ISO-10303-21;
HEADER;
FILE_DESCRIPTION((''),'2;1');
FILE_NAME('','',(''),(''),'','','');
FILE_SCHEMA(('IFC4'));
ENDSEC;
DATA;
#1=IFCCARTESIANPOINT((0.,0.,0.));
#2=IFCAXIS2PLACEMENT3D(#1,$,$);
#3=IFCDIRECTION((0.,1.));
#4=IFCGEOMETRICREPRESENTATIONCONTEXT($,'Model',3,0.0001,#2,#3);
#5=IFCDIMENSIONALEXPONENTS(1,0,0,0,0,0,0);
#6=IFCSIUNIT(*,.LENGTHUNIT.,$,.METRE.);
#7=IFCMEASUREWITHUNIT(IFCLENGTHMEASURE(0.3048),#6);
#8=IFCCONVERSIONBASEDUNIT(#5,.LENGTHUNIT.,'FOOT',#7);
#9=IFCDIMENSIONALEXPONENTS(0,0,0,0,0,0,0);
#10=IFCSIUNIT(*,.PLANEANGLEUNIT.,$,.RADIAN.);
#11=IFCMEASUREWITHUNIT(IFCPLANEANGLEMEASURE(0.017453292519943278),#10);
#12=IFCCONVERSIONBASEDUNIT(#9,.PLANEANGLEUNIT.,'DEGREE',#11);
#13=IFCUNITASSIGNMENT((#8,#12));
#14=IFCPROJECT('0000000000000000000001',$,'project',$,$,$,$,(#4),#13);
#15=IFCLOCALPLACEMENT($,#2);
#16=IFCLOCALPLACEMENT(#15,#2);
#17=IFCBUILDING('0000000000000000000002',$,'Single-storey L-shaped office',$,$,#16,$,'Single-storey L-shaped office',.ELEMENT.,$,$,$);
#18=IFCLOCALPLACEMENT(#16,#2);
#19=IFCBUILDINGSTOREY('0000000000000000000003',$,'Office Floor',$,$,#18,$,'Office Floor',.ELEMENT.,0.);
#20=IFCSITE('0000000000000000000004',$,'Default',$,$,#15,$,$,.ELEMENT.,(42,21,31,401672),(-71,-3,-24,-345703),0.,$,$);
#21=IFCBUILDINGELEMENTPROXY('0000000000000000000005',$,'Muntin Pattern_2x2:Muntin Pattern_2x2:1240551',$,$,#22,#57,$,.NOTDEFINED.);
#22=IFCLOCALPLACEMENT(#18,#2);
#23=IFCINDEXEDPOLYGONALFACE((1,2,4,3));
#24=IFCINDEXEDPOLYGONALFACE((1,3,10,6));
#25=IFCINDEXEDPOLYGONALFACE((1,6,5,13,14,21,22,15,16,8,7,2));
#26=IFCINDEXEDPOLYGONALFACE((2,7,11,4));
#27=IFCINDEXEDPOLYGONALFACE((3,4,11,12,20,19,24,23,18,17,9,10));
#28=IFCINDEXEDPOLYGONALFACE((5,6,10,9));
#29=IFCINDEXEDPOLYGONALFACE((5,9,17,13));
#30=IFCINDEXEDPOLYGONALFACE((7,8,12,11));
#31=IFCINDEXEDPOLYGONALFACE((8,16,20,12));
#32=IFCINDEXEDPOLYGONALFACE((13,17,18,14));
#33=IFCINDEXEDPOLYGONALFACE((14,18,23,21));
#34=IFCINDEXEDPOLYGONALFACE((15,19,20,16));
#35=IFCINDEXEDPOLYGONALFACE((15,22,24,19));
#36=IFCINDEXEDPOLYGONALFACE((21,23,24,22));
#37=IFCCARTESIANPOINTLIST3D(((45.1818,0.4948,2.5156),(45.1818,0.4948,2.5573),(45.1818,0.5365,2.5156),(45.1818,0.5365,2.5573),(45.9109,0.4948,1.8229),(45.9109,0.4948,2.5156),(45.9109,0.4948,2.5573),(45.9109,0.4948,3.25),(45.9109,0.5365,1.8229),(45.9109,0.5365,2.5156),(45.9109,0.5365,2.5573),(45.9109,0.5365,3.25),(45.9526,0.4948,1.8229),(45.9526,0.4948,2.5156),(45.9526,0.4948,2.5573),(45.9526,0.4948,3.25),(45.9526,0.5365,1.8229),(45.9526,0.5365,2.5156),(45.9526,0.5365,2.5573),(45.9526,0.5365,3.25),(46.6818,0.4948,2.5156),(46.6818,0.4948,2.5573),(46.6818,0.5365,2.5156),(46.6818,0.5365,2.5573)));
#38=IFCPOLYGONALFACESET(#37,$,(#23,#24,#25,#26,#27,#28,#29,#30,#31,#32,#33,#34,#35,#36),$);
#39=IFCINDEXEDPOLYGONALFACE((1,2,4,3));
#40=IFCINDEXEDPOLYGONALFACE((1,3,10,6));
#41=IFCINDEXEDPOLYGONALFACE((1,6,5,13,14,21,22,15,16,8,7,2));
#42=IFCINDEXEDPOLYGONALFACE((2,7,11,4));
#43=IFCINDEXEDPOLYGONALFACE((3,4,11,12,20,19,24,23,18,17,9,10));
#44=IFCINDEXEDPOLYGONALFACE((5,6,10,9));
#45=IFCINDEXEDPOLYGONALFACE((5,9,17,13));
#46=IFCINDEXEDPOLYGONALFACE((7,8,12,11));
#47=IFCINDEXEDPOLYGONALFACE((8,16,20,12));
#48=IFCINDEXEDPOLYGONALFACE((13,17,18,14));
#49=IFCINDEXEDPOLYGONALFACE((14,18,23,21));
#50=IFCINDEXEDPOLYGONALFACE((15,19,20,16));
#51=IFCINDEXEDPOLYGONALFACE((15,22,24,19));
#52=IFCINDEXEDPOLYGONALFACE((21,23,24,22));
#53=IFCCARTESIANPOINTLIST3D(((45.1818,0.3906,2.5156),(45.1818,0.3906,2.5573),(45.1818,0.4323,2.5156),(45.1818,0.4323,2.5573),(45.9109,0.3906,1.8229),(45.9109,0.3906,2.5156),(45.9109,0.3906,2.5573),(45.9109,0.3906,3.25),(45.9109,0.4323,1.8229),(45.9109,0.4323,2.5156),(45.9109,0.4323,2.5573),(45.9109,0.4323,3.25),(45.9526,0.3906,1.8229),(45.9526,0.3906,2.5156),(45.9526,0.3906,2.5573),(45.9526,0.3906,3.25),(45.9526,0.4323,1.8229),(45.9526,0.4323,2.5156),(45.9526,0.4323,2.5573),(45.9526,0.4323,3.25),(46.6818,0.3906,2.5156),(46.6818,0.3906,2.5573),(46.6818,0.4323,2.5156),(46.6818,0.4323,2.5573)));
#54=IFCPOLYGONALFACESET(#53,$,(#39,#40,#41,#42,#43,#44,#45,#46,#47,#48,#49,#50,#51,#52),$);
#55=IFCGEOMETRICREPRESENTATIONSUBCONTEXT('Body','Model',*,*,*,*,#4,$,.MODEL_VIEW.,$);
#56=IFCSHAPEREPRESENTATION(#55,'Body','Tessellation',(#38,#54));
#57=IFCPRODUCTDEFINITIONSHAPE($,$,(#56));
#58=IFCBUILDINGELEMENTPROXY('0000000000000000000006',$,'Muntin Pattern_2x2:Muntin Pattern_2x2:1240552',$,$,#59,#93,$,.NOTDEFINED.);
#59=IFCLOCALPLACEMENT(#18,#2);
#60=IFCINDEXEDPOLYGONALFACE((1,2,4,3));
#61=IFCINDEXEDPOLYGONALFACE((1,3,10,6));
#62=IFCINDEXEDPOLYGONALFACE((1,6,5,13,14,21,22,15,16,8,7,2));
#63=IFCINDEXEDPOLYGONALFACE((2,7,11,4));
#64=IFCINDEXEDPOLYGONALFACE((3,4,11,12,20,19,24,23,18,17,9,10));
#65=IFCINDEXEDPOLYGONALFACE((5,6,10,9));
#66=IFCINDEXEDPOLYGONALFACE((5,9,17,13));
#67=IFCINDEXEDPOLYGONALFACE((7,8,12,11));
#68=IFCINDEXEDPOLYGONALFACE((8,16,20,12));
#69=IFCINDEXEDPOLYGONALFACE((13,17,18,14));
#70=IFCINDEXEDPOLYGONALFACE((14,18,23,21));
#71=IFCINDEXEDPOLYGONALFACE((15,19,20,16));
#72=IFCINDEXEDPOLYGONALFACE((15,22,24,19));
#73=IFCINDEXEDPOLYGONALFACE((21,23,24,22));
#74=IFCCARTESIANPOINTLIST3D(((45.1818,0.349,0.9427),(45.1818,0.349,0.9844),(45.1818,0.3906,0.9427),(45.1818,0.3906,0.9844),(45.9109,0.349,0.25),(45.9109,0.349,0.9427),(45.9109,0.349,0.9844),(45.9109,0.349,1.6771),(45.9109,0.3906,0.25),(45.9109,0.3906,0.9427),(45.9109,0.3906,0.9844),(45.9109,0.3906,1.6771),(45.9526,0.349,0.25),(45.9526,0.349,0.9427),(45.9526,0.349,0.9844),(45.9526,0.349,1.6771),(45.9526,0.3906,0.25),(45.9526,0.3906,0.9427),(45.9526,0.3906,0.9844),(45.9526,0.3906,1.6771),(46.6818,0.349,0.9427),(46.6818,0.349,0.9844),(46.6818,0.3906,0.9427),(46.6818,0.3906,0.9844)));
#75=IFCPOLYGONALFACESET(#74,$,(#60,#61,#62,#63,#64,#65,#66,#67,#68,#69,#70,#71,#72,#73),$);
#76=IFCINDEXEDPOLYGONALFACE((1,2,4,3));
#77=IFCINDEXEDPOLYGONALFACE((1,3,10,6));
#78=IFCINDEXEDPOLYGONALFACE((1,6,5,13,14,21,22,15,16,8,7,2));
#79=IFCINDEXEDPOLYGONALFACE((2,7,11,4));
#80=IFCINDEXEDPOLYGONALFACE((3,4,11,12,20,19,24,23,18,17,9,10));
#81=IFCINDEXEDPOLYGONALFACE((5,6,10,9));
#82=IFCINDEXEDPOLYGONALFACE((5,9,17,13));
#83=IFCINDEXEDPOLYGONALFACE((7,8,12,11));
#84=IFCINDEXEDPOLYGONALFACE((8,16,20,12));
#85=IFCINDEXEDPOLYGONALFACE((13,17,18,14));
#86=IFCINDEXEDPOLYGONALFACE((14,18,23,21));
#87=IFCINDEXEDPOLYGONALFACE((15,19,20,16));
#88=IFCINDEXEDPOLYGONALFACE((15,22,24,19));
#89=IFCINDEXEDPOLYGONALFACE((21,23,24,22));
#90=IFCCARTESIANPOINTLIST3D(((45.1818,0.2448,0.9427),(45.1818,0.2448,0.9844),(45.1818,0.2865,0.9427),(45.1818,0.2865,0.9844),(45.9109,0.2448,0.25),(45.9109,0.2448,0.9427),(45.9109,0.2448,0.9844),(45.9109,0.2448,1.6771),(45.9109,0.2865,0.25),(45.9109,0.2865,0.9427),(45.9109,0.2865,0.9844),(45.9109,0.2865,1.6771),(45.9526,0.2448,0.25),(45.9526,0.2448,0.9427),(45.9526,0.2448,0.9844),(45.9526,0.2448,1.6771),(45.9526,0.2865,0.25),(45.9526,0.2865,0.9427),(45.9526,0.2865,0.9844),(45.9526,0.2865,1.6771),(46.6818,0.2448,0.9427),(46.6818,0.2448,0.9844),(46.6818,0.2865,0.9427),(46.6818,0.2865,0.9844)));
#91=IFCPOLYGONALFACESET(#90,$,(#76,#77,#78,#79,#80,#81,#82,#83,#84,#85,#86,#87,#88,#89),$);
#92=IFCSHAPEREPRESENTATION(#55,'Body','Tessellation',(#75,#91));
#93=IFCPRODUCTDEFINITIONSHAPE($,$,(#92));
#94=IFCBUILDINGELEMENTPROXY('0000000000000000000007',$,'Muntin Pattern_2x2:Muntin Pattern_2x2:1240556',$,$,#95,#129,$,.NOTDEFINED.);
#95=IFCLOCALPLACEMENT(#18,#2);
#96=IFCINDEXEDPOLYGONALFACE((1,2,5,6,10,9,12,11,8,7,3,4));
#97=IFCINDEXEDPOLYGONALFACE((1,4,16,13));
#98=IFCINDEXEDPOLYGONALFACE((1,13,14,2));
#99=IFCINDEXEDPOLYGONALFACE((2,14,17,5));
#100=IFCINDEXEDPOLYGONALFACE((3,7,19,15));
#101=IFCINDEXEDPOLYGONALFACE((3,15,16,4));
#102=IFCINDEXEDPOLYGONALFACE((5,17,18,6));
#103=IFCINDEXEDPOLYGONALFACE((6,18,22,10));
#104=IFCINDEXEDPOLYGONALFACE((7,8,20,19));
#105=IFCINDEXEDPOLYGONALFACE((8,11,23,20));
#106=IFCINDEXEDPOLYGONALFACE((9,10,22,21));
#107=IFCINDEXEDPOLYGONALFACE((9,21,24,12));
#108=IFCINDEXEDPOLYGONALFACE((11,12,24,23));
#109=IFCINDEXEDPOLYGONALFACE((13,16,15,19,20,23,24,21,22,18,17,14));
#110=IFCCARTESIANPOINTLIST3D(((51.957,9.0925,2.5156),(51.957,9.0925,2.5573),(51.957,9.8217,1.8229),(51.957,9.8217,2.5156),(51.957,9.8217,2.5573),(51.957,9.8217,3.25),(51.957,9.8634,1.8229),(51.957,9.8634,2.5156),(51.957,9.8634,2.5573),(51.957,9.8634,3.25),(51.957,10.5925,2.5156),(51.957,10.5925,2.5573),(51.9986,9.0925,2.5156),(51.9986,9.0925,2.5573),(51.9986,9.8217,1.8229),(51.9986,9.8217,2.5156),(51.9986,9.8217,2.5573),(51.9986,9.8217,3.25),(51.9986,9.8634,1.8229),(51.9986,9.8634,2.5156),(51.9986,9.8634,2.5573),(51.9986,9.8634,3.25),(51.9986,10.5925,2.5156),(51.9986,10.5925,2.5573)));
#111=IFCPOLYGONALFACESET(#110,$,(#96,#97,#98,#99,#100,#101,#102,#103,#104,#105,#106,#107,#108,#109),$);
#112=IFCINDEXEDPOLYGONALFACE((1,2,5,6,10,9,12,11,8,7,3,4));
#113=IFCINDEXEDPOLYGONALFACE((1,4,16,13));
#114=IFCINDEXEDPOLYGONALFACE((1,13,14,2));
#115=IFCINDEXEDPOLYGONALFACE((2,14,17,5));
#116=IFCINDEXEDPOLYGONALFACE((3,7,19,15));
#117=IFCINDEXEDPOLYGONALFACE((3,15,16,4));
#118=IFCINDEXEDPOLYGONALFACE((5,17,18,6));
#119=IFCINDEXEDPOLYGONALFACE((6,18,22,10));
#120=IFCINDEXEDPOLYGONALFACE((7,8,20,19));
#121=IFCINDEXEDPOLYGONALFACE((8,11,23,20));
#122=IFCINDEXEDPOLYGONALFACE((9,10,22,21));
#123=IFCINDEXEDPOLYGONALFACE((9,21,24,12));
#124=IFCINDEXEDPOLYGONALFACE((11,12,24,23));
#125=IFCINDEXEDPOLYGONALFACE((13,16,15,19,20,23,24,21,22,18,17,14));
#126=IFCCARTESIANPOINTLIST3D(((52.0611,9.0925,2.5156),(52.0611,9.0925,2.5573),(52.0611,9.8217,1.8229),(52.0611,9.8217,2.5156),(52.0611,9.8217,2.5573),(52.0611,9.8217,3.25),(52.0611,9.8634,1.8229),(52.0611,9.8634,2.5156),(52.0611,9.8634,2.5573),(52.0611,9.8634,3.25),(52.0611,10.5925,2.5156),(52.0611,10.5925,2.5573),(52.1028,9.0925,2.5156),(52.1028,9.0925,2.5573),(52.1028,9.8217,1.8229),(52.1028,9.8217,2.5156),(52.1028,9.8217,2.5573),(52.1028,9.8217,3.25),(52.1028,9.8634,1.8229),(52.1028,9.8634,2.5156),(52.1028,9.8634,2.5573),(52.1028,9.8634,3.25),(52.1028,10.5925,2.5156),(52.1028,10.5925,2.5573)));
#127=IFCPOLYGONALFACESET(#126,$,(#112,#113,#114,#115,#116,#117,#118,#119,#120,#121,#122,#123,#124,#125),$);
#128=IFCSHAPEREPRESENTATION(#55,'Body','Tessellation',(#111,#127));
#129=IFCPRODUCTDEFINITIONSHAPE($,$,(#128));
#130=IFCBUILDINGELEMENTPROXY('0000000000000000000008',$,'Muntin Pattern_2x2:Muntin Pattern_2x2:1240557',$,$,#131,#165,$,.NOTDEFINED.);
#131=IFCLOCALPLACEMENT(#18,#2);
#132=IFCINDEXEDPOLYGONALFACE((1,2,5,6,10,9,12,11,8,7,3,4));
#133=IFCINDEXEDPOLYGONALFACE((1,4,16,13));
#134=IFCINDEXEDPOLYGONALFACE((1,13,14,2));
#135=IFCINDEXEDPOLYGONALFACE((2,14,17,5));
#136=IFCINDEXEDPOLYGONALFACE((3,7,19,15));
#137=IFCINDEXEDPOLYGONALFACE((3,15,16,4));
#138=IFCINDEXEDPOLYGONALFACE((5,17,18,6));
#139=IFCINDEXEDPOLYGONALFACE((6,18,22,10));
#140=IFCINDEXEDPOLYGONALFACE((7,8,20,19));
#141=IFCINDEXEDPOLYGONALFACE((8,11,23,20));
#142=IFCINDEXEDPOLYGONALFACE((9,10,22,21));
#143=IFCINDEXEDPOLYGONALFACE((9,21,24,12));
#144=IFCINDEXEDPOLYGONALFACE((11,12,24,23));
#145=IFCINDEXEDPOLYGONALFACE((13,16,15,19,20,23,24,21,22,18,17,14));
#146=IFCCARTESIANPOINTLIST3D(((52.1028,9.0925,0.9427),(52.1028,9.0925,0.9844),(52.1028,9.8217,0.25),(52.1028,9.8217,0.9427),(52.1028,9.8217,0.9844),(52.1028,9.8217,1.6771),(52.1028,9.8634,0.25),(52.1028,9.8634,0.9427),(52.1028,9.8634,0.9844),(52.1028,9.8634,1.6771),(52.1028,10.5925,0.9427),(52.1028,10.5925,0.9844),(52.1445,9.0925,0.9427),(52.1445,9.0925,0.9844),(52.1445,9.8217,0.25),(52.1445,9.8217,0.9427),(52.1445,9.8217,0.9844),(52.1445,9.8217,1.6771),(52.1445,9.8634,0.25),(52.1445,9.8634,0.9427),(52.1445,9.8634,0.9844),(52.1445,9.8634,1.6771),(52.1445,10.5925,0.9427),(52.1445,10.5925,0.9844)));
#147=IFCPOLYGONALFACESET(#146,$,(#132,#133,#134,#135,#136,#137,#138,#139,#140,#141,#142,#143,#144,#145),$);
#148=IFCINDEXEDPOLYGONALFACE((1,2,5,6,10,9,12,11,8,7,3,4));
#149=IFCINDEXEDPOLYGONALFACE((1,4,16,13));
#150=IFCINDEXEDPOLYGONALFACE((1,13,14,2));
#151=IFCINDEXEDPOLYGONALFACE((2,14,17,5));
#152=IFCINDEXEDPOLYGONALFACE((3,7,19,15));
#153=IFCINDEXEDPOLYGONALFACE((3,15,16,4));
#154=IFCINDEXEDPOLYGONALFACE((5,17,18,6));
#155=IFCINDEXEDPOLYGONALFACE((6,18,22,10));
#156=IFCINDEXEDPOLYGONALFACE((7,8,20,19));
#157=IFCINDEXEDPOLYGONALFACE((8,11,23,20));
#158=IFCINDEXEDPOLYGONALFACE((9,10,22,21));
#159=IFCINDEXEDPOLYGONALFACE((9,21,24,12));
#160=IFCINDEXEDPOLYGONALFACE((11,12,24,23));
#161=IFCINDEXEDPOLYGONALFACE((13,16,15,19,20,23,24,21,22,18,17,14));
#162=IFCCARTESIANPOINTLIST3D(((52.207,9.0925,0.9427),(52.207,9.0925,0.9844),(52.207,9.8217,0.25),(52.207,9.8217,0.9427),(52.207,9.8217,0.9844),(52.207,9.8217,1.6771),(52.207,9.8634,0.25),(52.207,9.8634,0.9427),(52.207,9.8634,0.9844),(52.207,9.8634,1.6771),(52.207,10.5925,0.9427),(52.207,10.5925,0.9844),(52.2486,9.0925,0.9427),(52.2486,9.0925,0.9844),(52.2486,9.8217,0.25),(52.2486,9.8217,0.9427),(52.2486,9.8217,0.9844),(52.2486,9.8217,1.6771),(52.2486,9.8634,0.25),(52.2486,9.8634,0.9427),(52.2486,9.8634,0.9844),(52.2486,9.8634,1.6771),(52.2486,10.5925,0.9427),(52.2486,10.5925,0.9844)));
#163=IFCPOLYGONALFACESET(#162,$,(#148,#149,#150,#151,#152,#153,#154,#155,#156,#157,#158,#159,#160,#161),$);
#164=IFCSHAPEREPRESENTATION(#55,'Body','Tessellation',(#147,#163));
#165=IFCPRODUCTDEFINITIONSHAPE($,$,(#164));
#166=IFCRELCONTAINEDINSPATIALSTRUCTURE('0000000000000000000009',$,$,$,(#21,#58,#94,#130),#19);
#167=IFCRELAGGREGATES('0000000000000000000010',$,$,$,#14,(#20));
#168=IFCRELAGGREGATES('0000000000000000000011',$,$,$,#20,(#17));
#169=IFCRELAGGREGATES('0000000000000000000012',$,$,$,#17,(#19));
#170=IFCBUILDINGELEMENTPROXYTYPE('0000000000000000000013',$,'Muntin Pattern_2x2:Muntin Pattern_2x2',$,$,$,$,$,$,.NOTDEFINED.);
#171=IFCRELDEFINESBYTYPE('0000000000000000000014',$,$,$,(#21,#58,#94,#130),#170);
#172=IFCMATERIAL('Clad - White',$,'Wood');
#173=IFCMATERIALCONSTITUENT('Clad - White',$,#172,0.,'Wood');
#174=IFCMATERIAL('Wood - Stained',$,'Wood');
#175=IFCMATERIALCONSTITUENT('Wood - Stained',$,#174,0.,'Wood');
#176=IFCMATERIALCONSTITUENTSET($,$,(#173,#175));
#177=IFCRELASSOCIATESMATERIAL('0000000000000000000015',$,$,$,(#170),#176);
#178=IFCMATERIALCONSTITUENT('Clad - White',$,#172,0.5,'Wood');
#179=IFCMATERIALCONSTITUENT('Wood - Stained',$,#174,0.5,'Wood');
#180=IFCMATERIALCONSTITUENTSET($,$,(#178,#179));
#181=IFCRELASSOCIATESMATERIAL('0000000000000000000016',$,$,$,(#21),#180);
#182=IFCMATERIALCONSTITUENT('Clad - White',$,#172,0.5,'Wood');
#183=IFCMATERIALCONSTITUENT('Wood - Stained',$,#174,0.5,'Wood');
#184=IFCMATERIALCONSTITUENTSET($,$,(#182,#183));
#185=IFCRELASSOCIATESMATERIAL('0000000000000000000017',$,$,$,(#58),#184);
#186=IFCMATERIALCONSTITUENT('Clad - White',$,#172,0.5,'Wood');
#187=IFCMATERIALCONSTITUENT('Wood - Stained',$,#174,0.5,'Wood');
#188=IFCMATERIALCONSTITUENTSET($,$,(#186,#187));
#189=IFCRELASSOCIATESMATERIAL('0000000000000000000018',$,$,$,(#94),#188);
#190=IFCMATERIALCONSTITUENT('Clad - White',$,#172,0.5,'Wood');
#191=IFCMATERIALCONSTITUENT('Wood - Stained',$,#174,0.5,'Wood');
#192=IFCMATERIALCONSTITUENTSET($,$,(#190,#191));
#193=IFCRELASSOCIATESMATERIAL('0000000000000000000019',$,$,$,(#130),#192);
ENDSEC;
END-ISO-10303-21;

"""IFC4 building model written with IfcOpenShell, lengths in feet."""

from ifc_helpers import new_model, entity, si_unit, converted_unit, direction, frame, origin, place, context, subcontext, project, spatial, indexed_curve, outline, extrude, source, transform, mapped, material, constituent, constituent_set, type_object, type_shapes, element, save


model = new_model("IFC4")

# Units and contexts
model_context = context("Model", 3, precision=0.0001, world=origin(), true_north=direction((0.0, 1.0)))
body_context = subcontext(model_context, "Body", "Model", "MODEL_VIEW")
ifc_project = project(units=[converted_unit("LENGTHUNIT", "FOOT", entity("IfcLengthMeasure", 0.3048), si_unit("LENGTHUNIT", "METRE"), dimensions=[1, 0, 0, 0, 0, 0, 0]), converted_unit("PLANEANGLEUNIT", "DEGREE", entity("IfcPlaneAngleMeasure", 0.017453292519943278), si_unit("PLANEANGLEUNIT", "RADIAN"), dimensions=[0, 0, 0, 0, 0, 0, 0])], contexts=[model_context])

# Site, building, storey
site_placement = place(None, origin())
site = spatial("IfcSite", under=ifc_project, at=site_placement, Name="Default", CompositionType="ELEMENT", RefLatitude=(42, 21, 31, 401672), RefLongitude=(-71, -3, -24, -345703), RefElevation=0.0)
building_placement = place(site_placement, origin())
building = spatial("IfcBuilding", under=site, at=building_placement, Name="Single-storey L-shaped office", LongName="Single-storey L-shaped office", CompositionType="ELEMENT")
storey_placement = place(building_placement, origin())
storey = spatial("IfcBuildingStorey", under=building, at=storey_placement, Name="Office Floor", LongName="Office Floor", CompositionType="ELEMENT", Elevation=0.0)

# Shared definitions
ifc_material_1 = material(Name="Wood - Stained", Category="Wood")

# Building element proxies
ifc_material_2 = material(Name="Clad - White", Category="Wood")
ifc_constituent_1 = constituent(ifc_material_2, Name="Clad - White", Category="Wood", fraction=0.5)
ifc_constituent_2 = constituent(ifc_material_1, Name="Wood - Stained", Category="Wood", fraction=0.5)
ifc_constituent_set_1 = constituent_set(constituents=[ifc_constituent_1, ifc_constituent_2])
ifc_constituent_3 = constituent(ifc_material_2, Name="Clad - White", Category="Wood", fraction=0.0)
ifc_constituent_4 = constituent(ifc_material_1, Name="Wood - Stained", Category="Wood", fraction=0.0)
ifc_constituent_set_2 = constituent_set(constituents=[ifc_constituent_3, ifc_constituent_4])
building_element_proxy_type_1 = type_object("IfcBuildingElementProxyType", Name="Muntin Pattern_2x2:Muntin Pattern_2x2", PredefinedType="NOTDEFINED", material=ifc_constituent_set_2)
shared_shape_1 = source(origin(), body_context, "Body", "SweptSolid", [
    extrude(outline(indexed_curve([(0.0208, -0.0208), (0.7135, -0.0208), (0.7135, 0.0208), (0.0208, 0.0208), (0.0208, 0.75), (-0.0208, 0.75), (-0.0208, 0.0208), (-0.7135, 0.0208), (-0.7135, -0.0208), (-0.0208, -0.0208), (-0.0208, -0.75), (0.0208, -0.75), (0.0208, -0.0208)], self_intersect=False)), frame((0.0, 0.0312, 0.7135), z_axis=(0.0, 1.0, 0.0), x_axis=(0.0, 0.0, 1.0)), (0.0, 0.0, 1.0), 0.0417),
    extrude(outline(indexed_curve([(0.0208, -0.0208), (0.7135, -0.0208), (0.7135, 0.0208), (0.0208, 0.0208), (0.0208, 0.75), (-0.0208, 0.75), (-0.0208, 0.0208), (-0.7135, 0.0208), (-0.7135, -0.0208), (-0.0208, -0.0208), (-0.0208, -0.75), (0.0208, -0.75), (0.0208, -0.0208)], self_intersect=False)), frame((0.0, -0.0729, 0.7135), z_axis=(0.0, 1.0, 0.0), x_axis=(0.0, 0.0, 1.0)), (0.0, 0.0, 1.0), 0.0417),
])
type_shapes(building_element_proxy_type_1, [shared_shape_1])
proxy_1_placement = place(storey_placement, frame((45.9318, 0.4635, 1.8229)))
element("IfcBuildingElementProxy", 1, at=proxy_1_placement, inside=storey, type_object=building_element_proxy_type_1, material=ifc_constituent_set_1, Name="Muntin Pattern_2x2:Muntin Pattern_2x2:1240551", PredefinedType="NOTDEFINED", context=body_context, shape_type="MappedRepresentation", body=[
    mapped(shared_shape_1, transform((0.0, 0.0, 0.0), scale=1.0)),
])
ifc_constituent_5 = constituent(ifc_material_2, Name="Clad - White", Category="Wood", fraction=0.5)
ifc_constituent_6 = constituent(ifc_material_1, Name="Wood - Stained", Category="Wood", fraction=0.5)
ifc_constituent_set_3 = constituent_set(constituents=[ifc_constituent_5, ifc_constituent_6])
proxy_2_placement = place(storey_placement, frame((45.9318, 0.3177, 0.25)))
element("IfcBuildingElementProxy", 2, at=proxy_2_placement, inside=storey, type_object=building_element_proxy_type_1, material=ifc_constituent_set_3, Name="Muntin Pattern_2x2:Muntin Pattern_2x2:1240552", PredefinedType="NOTDEFINED", context=body_context, shape_type="MappedRepresentation", body=[
    mapped(shared_shape_1, transform((0.0, 0.0, 0.0), scale=1.0)),
])
ifc_constituent_7 = constituent(ifc_material_2, Name="Clad - White", Category="Wood", fraction=0.5)
ifc_constituent_8 = constituent(ifc_material_1, Name="Wood - Stained", Category="Wood", fraction=0.5)
ifc_constituent_set_4 = constituent_set(constituents=[ifc_constituent_7, ifc_constituent_8])
proxy_3_placement = place(storey_placement, frame((52.0299, 9.8425, 1.8229), z_axis=(0.0, 0.0, 1.0), x_axis=(0.0, 1.0, 0.0)))
element("IfcBuildingElementProxy", 3, at=proxy_3_placement, inside=storey, type_object=building_element_proxy_type_1, material=ifc_constituent_set_4, Name="Muntin Pattern_2x2:Muntin Pattern_2x2:1240556", PredefinedType="NOTDEFINED", context=body_context, shape_type="MappedRepresentation", body=[
    mapped(shared_shape_1, transform((0.0, 0.0, 0.0), scale=1.0)),
])
ifc_constituent_9 = constituent(ifc_material_2, Name="Clad - White", Category="Wood", fraction=0.5)
ifc_constituent_10 = constituent(ifc_material_1, Name="Wood - Stained", Category="Wood", fraction=0.5)
ifc_constituent_set_5 = constituent_set(constituents=[ifc_constituent_9, ifc_constituent_10])
proxy_4_placement = place(storey_placement, frame((52.1757, 9.8425, 0.25), z_axis=(0.0, 0.0, 1.0), x_axis=(0.0, 1.0, 0.0)))
element("IfcBuildingElementProxy", 4, at=proxy_4_placement, inside=storey, type_object=building_element_proxy_type_1, material=ifc_constituent_set_5, Name="Muntin Pattern_2x2:Muntin Pattern_2x2:1240557", PredefinedType="NOTDEFINED", context=body_context, shape_type="MappedRepresentation", body=[
    mapped(shared_shape_1, transform((0.0, 0.0, 0.0), scale=1.0)),
])

save(model, "model.ifc")
